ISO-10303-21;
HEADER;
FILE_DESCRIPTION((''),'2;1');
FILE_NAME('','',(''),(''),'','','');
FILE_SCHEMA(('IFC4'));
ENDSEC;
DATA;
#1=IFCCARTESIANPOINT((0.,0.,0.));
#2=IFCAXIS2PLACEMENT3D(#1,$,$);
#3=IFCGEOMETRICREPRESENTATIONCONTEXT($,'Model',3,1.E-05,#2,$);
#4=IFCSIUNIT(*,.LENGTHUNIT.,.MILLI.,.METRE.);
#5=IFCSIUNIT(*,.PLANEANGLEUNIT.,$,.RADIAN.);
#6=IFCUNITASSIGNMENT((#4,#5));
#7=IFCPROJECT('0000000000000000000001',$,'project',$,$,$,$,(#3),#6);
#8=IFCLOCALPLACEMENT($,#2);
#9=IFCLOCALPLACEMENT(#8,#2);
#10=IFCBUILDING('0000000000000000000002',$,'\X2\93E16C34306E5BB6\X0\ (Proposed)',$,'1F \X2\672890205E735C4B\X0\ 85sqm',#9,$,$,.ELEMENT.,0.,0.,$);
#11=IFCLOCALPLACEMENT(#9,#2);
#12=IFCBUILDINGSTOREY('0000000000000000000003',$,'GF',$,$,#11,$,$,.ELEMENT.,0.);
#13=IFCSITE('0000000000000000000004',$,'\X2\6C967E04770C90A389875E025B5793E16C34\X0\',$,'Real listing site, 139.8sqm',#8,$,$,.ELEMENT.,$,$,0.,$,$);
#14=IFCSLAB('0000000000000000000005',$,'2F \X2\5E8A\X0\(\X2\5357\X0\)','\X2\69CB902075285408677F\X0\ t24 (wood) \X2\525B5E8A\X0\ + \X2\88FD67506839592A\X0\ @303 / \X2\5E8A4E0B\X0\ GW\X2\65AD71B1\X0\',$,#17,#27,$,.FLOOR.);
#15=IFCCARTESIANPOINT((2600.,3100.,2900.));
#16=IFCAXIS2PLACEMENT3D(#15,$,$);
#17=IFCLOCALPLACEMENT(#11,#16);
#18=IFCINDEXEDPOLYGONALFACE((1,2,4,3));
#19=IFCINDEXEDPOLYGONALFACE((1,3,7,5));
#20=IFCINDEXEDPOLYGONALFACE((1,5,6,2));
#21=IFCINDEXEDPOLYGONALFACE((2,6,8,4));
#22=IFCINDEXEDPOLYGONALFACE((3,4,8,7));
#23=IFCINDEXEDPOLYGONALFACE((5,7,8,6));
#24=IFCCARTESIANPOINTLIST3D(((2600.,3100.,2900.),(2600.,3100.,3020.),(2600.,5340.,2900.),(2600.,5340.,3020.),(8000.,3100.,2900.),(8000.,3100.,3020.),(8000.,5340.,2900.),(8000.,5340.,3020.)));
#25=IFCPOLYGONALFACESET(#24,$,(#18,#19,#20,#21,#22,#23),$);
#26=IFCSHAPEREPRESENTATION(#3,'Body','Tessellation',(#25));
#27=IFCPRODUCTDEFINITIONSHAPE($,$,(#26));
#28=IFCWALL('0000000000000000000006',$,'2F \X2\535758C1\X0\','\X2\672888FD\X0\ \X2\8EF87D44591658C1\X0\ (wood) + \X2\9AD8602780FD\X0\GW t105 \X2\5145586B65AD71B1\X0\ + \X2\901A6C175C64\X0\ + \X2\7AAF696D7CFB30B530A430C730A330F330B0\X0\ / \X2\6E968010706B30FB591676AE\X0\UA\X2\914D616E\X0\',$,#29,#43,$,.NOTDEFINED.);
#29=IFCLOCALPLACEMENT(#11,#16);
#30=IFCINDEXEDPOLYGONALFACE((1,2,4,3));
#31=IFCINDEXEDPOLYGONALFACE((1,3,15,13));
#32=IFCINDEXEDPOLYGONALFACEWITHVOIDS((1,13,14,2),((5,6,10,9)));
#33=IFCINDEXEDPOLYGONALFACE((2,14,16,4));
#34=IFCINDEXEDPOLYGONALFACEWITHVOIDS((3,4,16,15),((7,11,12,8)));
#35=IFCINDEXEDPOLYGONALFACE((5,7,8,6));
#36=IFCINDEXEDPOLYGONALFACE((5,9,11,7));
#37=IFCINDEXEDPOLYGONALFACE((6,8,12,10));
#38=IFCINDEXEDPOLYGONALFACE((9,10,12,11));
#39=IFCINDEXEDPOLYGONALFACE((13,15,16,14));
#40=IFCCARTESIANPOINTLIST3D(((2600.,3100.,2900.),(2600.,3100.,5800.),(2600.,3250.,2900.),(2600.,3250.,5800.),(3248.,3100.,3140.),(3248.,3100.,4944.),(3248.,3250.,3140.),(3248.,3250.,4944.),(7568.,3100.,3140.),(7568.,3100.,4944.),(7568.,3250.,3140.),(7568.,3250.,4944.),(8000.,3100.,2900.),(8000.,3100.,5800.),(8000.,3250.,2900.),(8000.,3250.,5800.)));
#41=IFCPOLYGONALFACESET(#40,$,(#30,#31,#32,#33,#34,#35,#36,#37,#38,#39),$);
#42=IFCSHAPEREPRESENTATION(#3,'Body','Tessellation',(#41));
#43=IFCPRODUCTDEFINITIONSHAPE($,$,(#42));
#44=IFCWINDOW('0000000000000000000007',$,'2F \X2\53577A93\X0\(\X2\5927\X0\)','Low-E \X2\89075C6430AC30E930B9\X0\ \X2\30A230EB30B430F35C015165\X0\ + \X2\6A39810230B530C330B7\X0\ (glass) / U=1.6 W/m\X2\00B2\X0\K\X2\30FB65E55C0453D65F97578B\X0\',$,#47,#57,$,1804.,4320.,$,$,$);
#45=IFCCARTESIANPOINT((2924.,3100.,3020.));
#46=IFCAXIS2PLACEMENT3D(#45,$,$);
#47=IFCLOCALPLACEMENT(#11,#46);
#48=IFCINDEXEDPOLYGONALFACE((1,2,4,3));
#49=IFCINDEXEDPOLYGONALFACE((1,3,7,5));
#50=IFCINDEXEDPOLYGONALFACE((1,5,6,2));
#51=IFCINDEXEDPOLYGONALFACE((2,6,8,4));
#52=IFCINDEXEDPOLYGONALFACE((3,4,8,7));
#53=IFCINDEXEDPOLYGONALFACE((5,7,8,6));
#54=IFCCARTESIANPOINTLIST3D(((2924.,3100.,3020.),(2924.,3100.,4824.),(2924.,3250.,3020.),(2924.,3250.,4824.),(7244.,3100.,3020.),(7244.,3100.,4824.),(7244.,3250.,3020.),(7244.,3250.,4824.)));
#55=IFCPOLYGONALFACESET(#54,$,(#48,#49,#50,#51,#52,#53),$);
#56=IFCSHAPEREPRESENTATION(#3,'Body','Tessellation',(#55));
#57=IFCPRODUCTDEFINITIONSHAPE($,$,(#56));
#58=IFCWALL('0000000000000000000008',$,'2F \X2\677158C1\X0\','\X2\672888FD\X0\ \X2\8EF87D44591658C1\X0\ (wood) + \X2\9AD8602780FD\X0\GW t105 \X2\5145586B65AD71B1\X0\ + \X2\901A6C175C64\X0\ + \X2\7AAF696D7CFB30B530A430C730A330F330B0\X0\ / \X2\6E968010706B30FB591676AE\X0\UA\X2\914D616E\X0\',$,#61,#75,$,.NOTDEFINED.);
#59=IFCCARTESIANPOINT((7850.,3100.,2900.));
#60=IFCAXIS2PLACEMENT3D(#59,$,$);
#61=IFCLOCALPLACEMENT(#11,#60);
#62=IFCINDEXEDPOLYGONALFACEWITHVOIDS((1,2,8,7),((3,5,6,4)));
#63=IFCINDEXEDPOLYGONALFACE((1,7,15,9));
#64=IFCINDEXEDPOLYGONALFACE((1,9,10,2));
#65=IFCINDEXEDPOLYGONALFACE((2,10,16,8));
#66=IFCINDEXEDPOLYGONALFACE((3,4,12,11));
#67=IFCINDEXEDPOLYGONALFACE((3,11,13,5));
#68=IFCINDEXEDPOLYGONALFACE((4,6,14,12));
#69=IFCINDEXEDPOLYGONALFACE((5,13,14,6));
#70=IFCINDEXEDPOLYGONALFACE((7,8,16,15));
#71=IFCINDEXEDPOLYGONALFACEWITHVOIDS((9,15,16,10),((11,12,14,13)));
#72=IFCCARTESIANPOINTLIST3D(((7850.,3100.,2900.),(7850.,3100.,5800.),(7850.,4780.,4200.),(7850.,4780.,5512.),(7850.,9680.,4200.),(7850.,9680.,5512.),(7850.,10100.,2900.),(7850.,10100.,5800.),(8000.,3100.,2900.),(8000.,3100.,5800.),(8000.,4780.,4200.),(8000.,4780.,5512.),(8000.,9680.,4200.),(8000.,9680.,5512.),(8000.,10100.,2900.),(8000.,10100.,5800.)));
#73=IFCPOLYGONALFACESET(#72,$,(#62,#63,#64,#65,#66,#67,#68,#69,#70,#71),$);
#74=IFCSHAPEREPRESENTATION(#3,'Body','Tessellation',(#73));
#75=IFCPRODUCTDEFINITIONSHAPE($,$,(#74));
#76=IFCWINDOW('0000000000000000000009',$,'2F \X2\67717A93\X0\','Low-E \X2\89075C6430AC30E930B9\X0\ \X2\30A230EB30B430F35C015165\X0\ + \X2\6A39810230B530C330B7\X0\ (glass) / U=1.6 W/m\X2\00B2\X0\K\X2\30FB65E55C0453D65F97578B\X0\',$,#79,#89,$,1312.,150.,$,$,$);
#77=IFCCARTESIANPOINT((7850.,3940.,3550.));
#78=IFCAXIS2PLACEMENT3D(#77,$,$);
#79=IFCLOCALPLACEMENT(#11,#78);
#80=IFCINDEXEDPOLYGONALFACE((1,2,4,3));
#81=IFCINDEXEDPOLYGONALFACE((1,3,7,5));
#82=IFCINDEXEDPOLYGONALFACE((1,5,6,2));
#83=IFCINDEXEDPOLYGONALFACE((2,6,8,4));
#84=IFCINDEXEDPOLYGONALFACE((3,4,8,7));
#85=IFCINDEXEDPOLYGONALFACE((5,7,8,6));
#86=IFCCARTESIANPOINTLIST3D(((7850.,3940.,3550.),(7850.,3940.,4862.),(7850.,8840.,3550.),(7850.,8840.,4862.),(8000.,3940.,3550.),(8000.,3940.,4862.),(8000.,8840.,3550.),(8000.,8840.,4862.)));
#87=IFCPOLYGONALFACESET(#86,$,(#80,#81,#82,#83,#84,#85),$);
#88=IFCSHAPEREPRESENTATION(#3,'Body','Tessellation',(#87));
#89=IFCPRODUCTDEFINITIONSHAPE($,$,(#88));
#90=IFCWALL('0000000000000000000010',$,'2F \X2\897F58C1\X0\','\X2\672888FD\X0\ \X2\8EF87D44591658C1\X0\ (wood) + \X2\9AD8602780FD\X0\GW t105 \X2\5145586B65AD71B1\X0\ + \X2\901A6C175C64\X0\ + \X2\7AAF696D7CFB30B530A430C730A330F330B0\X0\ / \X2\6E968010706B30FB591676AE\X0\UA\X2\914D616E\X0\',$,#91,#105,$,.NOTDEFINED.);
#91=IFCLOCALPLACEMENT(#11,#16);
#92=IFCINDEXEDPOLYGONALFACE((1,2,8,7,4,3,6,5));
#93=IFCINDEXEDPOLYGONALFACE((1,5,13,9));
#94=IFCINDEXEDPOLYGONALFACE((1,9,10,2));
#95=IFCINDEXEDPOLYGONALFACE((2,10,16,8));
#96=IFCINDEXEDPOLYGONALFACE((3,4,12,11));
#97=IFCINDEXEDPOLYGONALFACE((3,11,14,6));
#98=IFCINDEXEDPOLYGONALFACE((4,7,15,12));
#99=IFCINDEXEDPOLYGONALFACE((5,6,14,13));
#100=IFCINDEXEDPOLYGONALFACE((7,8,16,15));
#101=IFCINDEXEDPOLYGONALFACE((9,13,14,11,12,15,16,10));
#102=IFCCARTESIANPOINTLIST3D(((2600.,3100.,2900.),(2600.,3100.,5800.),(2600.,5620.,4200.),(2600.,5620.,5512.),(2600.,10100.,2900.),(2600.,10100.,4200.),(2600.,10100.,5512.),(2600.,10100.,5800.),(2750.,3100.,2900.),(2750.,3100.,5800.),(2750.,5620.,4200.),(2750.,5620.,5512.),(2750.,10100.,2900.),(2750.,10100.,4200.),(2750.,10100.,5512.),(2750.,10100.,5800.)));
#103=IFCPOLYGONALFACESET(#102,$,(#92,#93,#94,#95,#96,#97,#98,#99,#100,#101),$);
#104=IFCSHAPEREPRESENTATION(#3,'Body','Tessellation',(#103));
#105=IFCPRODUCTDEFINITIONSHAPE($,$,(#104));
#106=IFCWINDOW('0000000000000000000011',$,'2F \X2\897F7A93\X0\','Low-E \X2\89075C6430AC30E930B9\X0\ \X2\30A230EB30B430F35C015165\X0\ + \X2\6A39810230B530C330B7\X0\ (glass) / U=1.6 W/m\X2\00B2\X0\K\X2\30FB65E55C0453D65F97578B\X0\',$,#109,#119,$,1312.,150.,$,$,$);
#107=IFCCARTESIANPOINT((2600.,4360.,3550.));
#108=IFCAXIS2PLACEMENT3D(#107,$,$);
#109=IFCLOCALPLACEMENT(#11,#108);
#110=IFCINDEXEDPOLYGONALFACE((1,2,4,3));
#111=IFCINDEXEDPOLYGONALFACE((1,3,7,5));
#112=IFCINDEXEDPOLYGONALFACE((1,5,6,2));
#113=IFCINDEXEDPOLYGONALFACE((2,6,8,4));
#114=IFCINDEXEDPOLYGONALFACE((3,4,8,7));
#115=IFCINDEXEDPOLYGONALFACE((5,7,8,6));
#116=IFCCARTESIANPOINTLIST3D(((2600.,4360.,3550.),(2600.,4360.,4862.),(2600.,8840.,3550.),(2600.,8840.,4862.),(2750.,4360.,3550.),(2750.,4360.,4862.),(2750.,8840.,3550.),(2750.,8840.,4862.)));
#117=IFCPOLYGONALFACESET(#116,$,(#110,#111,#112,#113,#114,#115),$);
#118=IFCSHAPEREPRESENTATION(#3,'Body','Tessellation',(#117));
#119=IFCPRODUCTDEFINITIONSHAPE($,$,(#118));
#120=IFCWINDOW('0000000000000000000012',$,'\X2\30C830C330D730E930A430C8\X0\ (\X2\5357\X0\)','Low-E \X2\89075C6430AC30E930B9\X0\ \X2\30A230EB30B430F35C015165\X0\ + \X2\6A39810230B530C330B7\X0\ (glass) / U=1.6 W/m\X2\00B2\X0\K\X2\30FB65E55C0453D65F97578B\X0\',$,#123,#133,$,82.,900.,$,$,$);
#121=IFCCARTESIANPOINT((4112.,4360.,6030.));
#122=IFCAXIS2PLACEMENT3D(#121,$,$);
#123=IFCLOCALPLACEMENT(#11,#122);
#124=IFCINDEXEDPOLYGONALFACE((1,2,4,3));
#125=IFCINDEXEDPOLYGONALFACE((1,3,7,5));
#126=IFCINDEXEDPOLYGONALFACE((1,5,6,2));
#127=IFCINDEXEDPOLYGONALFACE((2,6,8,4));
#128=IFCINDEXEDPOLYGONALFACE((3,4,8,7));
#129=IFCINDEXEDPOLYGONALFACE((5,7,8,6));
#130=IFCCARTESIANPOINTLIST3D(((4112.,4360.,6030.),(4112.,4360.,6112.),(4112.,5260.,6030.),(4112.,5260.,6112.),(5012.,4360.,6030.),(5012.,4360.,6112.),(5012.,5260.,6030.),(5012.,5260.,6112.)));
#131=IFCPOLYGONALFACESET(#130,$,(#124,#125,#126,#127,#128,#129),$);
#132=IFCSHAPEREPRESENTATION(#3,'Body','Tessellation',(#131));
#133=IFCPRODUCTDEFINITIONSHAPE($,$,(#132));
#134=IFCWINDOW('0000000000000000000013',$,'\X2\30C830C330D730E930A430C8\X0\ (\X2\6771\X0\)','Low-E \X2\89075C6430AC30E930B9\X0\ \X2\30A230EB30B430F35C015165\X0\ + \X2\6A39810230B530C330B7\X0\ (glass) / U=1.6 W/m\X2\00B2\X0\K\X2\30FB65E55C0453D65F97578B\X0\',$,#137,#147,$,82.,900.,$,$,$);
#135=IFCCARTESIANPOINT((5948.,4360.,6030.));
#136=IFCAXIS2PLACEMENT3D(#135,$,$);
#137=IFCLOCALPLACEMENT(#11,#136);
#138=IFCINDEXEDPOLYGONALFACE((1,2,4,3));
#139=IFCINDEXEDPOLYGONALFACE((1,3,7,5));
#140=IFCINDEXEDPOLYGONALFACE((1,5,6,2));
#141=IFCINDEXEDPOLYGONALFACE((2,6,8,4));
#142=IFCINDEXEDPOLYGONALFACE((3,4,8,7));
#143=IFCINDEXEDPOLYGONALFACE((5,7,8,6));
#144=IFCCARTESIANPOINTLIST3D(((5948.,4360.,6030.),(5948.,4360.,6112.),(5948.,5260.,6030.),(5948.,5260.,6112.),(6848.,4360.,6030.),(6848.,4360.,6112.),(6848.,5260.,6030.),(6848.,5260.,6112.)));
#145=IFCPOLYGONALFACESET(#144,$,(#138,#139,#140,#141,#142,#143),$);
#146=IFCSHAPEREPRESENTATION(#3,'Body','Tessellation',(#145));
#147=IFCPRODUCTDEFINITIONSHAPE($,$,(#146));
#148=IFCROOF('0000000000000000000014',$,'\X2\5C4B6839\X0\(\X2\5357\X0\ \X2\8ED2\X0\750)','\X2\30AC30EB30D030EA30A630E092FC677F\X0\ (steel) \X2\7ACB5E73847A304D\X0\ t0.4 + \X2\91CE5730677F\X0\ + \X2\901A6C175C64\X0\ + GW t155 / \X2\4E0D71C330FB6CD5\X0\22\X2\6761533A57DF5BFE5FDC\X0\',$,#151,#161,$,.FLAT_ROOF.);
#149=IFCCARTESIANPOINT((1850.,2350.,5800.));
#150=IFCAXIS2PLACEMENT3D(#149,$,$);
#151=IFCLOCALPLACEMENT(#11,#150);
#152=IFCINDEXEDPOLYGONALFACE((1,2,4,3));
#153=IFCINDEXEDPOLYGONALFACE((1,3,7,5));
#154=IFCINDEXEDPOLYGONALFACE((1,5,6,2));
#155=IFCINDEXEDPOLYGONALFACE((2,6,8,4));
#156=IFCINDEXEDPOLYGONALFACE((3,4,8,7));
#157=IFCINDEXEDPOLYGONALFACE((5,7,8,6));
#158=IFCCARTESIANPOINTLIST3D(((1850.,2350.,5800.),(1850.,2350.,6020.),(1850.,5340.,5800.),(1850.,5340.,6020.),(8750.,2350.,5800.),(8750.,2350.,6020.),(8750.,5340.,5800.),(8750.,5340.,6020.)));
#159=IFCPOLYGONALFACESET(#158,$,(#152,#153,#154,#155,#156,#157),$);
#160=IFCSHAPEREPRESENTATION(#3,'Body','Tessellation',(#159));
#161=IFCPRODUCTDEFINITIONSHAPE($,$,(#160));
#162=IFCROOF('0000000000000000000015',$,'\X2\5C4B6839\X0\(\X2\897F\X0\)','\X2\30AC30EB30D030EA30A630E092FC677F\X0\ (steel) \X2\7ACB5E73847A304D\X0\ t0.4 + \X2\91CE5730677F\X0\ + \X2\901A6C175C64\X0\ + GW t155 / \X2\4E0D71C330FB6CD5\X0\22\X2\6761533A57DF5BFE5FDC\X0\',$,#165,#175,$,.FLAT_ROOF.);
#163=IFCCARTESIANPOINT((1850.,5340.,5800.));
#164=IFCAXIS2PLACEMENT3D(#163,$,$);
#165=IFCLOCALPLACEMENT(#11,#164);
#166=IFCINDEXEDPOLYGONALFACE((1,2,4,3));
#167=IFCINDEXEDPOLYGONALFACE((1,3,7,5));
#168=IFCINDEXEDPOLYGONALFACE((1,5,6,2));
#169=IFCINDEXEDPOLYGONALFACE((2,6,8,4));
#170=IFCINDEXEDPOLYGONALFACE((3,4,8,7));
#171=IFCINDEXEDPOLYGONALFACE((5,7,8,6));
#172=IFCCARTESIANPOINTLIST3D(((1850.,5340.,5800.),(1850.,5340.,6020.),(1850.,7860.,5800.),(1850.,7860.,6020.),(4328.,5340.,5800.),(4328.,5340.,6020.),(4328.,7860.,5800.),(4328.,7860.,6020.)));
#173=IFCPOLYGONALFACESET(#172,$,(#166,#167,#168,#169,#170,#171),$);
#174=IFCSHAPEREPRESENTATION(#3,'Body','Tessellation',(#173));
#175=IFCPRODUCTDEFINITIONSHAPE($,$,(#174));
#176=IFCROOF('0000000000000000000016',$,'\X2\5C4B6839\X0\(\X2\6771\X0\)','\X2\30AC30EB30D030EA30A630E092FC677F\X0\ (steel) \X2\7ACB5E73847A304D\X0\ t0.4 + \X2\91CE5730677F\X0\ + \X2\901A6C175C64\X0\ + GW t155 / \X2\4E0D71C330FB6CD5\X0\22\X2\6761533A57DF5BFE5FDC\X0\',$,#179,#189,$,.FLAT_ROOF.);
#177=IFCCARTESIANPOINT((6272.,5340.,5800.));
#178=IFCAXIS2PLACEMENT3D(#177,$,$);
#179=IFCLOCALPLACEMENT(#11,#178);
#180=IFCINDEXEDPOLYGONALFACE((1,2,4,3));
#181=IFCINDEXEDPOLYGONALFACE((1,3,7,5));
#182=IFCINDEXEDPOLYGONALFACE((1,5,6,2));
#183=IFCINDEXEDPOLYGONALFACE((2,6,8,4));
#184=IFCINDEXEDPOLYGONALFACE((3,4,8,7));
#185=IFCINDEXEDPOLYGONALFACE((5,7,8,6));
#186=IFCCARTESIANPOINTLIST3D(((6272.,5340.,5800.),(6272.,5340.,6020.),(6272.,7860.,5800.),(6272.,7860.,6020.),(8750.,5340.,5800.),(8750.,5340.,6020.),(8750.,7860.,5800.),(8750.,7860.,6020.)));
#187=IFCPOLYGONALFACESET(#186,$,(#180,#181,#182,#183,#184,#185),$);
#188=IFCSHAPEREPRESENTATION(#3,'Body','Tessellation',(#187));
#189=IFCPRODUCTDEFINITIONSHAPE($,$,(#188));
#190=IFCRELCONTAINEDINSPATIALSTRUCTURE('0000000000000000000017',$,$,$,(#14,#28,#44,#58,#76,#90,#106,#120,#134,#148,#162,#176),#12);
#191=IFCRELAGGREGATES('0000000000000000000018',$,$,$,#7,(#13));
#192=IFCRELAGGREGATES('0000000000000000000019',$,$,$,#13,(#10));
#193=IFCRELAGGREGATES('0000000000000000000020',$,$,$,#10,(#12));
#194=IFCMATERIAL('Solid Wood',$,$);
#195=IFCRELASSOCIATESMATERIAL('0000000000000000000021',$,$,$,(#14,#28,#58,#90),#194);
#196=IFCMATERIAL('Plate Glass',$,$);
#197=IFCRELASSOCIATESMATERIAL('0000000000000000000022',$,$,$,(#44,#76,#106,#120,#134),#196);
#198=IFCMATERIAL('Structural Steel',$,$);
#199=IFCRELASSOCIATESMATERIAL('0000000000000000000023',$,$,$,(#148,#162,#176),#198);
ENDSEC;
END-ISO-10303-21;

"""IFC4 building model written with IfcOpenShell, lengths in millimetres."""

from ifc_helpers import new_model, si_unit, frame, frame_2d, origin, place, context, project, spatial, rectangle, extrude, material, element, fill, save


model = new_model("IFC4")

# Units and contexts
model_context = context("Model", 3, precision=1e-05, world=origin())
ifc_project = project(units=[si_unit("LENGTHUNIT", "METRE", prefix="MILLI"), si_unit("PLANEANGLEUNIT", "RADIAN")], contexts=[model_context])

# Site, building, storey
site_placement = place(None, origin())
site = spatial("IfcSite", under=ifc_project, at=site_placement, Name="沖縄県那覇市字鏡水", ObjectType="Real listing site, 139.8sqm", CompositionType="ELEMENT", RefElevation=0.0)
building_placement = place(site_placement, origin())
building = spatial("IfcBuilding", under=site, at=building_placement, Name="鏡水の家 (Proposed)", ObjectType="1F 木造平屋 85sqm", CompositionType="ELEMENT", ElevationOfRefHeight=0.0, ElevationOfTerrain=0.0)
storey_placement = place(building_placement, origin())
storey = spatial("IfcBuildingStorey", under=building, at=storey_placement, Name="GF", CompositionType="ELEMENT", Elevation=0.0)

# Slab
ifc_material_1 = material(Name="Solid Wood")
slab_placement = place(storey_placement, frame((2600.0, 3100.0, 2900.0)))
element("IfcSlab", 1, at=slab_placement, inside=storey, material=ifc_material_1, Name="2F 床(南)", Description="構造用合板 t24 (wood) 剛床 + 製材根太 @303 / 床下 GW断熱", PredefinedType="FLOOR", context=model_context, shape_type="SweptSolid", body=[
    extrude(rectangle(XDim=5400.0, YDim=2240.0, at=frame_2d((2700.0, 1120.0))), frame((2600.0, 3100.0, 2900.0)), (0.0, 0.0, 1.0), 120.0),
])

# Walls, openings, windows
wall_1_placement = place(storey_placement, frame((2600.0, 3100.0, 2900.0)))
wall_1 = element("IfcWall", 2, at=wall_1_placement, inside=storey, material=ifc_material_1, Name="2F 南壁", Description="木製 軸組外壁 (wood) + 高性能GW t105 充填断熱 + 通気層 + 窯業系サイディング / 準耐火・外皮UA配慮", PredefinedType="NOTDEFINED", context=model_context, shape_type="SweptSolid", body=[
    extrude(rectangle(XDim=5400.0, YDim=150.0, at=frame_2d((2700.0, 75.0))), frame((2600.0, 3100.0, 2900.0)), (0.0, 0.0, 1.0), 2900.0),
])
opening_1_placement = place(storey_placement, frame((2924.0, 3100.0, 3020.0)))
opening_1 = element("IfcOpeningElement", 3, at=opening_1_placement, cuts=wall_1, PredefinedType="NOTDEFINED", context=model_context, shape_type="SweptSolid", body=[
    extrude(rectangle(XDim=4320.0, YDim=150.0, at=frame_2d((2160.0, 75.0))), frame((2924.0, 3100.0, 3020.0)), (0.0, 0.0, 1.0), 1804.0),
])
ifc_material_2 = material(Name="Plate Glass")
window_1_placement = place(storey_placement, frame((2924.0, 3100.0, 3020.0)))
window_1 = element("IfcWindow", 4, at=window_1_placement, inside=storey, material=ifc_material_2, Name="2F 南窓(大)", Description="Low-E 複層ガラス アルゴン封入 + 樹脂サッシ (glass) / U=1.6 W/m²K・日射取得型", OverallHeight=1804.0, OverallWidth=4320.0, context=model_context, shape_type="SweptSolid", body=[
    extrude(rectangle(XDim=4320.0, YDim=150.0, at=frame_2d((2160.0, 75.0))), frame((2924.0, 3100.0, 3020.0)), (0.0, 0.0, 1.0), 1804.0),
])
fill(opening_1, window_1)
wall_2_placement = place(storey_placement, frame((7850.0, 3100.0, 2900.0)))
wall_2 = element("IfcWall", 5, at=wall_2_placement, inside=storey, material=ifc_material_1, Name="2F 東壁", Description="木製 軸組外壁 (wood) + 高性能GW t105 充填断熱 + 通気層 + 窯業系サイディング / 準耐火・外皮UA配慮", PredefinedType="NOTDEFINED", context=model_context, shape_type="SweptSolid", body=[
    extrude(rectangle(XDim=150.0, YDim=7000.0, at=frame_2d((75.0, 3500.0))), frame((7850.0, 3100.0, 2900.0)), (0.0, 0.0, 1.0), 2900.0),
])
opening_2_placement = place(storey_placement, frame((7850.0, 3940.0, 3550.0)))
opening_2 = element("IfcOpeningElement", 6, at=opening_2_placement, cuts=wall_2, PredefinedType="NOTDEFINED", context=model_context, shape_type="SweptSolid", body=[
    extrude(rectangle(XDim=150.0, YDim=4900.0, at=frame_2d((75.0, 2450.0))), frame((7850.0, 3940.0, 3550.0)), (0.0, 0.0, 1.0), 1312.0),
])
window_2_placement = place(storey_placement, frame((7850.0, 3940.0, 3550.0)))
window_2 = element("IfcWindow", 7, at=window_2_placement, inside=storey, material=ifc_material_2, Name="2F 東窓", Description="Low-E 複層ガラス アルゴン封入 + 樹脂サッシ (glass) / U=1.6 W/m²K・日射取得型", OverallHeight=1312.0, OverallWidth=150.0, context=model_context, shape_type="SweptSolid", body=[
    extrude(rectangle(XDim=150.0, YDim=4900.0, at=frame_2d((75.0, 2450.0))), frame((7850.0, 3940.0, 3550.0)), (0.0, 0.0, 1.0), 1312.0),
])
fill(opening_2, window_2)
wall_3_placement = place(storey_placement, frame((2600.0, 3100.0, 2900.0)))
wall_3 = element("IfcWall", 8, at=wall_3_placement, inside=storey, material=ifc_material_1, Name="2F 西壁", Description="木製 軸組外壁 (wood) + 高性能GW t105 充填断熱 + 通気層 + 窯業系サイディング / 準耐火・外皮UA配慮", PredefinedType="NOTDEFINED", context=model_context, shape_type="SweptSolid", body=[
    extrude(rectangle(XDim=150.0, YDim=7000.0, at=frame_2d((75.0, 3500.0))), frame((2600.0, 3100.0, 2900.0)), (0.0, 0.0, 1.0), 2900.0),
])
opening_3_placement = place(storey_placement, frame((2600.0, 4360.0, 3550.0)))
opening_3 = element("IfcOpeningElement", 9, at=opening_3_placement, cuts=wall_3, PredefinedType="NOTDEFINED", context=model_context, shape_type="SweptSolid", body=[
    extrude(rectangle(XDim=150.0, YDim=4480.0, at=frame_2d((75.0, 2240.0))), frame((2600.0, 4360.0, 3550.0)), (0.0, 0.0, 1.0), 1312.0),
])
window_3_placement = place(storey_placement, frame((2600.0, 4360.0, 3550.0)))
window_3 = element("IfcWindow", 10, at=window_3_placement, inside=storey, material=ifc_material_2, Name="2F 西窓", Description="Low-E 複層ガラス アルゴン封入 + 樹脂サッシ (glass) / U=1.6 W/m²K・日射取得型", OverallHeight=1312.0, OverallWidth=150.0, context=model_context, shape_type="SweptSolid", body=[
    extrude(rectangle(XDim=150.0, YDim=4480.0, at=frame_2d((75.0, 2240.0))), frame((2600.0, 4360.0, 3550.0)), (0.0, 0.0, 1.0), 1312.0),
])
fill(opening_3, window_3)

# Windows
window_4_placement = place(storey_placement, frame((4112.0, 4360.0, 6030.0)))
element("IfcWindow", 11, at=window_4_placement, inside=storey, material=ifc_material_2, Name="トップライト (南)", Description="Low-E 複層ガラス アルゴン封入 + 樹脂サッシ (glass) / U=1.6 W/m²K・日射取得型", OverallHeight=82.0, OverallWidth=900.0, context=model_context, shape_type="SweptSolid", body=[
    extrude(rectangle(XDim=900.0, YDim=900.0, at=frame_2d((450.0, 450.0))), frame((4112.0, 4360.0, 6030.0)), (0.0, 0.0, 1.0), 82.0),
])
window_5_placement = place(storey_placement, frame((5948.0, 4360.0, 6030.0)))
element("IfcWindow", 12, at=window_5_placement, inside=storey, material=ifc_material_2, Name="トップライト (東)", Description="Low-E 複層ガラス アルゴン封入 + 樹脂サッシ (glass) / U=1.6 W/m²K・日射取得型", OverallHeight=82.0, OverallWidth=900.0, context=model_context, shape_type="SweptSolid", body=[
    extrude(rectangle(XDim=900.0, YDim=900.0, at=frame_2d((450.0, 450.0))), frame((5948.0, 4360.0, 6030.0)), (0.0, 0.0, 1.0), 82.0),
])

# Roofs
ifc_material_3 = material(Name="Structural Steel")
roof_1_placement = place(storey_placement, frame((1850.0, 2350.0, 5800.0)))
element("IfcRoof", 13, at=roof_1_placement, inside=storey, material=ifc_material_3, Name="屋根(南 軒750)", Description="ガルバリウム鋼板 (steel) 立平葺き t0.4 + 野地板 + 通気層 + GW t155 / 不燃・法22条区域対応", PredefinedType="FLAT_ROOF", context=model_context, shape_type="SweptSolid", body=[
    extrude(rectangle(XDim=6900.0, YDim=2990.0, at=frame_2d((3450.0, 1495.0))), frame((1850.0, 2350.0, 5800.0)), (0.0, 0.0, 1.0), 220.0),
])
roof_2_placement = place(storey_placement, frame((1850.0, 5340.0, 5800.0)))
element("IfcRoof", 14, at=roof_2_placement, inside=storey, material=ifc_material_3, Name="屋根(西)", Description="ガルバリウム鋼板 (steel) 立平葺き t0.4 + 野地板 + 通気層 + GW t155 / 不燃・法22条区域対応", PredefinedType="FLAT_ROOF", context=model_context, shape_type="SweptSolid", body=[
    extrude(rectangle(XDim=2478.0, YDim=2520.0, at=frame_2d((1239.0, 1260.0))), frame((1850.0, 5340.0, 5800.0)), (0.0, 0.0, 1.0), 220.0),
])
roof_3_placement = place(storey_placement, frame((6272.0, 5340.0, 5800.0)))
element("IfcRoof", 15, at=roof_3_placement, inside=storey, material=ifc_material_3, Name="屋根(東)", Description="ガルバリウム鋼板 (steel) 立平葺き t0.4 + 野地板 + 通気層 + GW t155 / 不燃・法22条区域対応", PredefinedType="FLAT_ROOF", context=model_context, shape_type="SweptSolid", body=[
    extrude(rectangle(XDim=2478.0, YDim=2520.0, at=frame_2d((1239.0, 1260.0))), frame((6272.0, 5340.0, 5800.0)), (0.0, 0.0, 1.0), 220.0),
])

save(model, "model.ifc")
